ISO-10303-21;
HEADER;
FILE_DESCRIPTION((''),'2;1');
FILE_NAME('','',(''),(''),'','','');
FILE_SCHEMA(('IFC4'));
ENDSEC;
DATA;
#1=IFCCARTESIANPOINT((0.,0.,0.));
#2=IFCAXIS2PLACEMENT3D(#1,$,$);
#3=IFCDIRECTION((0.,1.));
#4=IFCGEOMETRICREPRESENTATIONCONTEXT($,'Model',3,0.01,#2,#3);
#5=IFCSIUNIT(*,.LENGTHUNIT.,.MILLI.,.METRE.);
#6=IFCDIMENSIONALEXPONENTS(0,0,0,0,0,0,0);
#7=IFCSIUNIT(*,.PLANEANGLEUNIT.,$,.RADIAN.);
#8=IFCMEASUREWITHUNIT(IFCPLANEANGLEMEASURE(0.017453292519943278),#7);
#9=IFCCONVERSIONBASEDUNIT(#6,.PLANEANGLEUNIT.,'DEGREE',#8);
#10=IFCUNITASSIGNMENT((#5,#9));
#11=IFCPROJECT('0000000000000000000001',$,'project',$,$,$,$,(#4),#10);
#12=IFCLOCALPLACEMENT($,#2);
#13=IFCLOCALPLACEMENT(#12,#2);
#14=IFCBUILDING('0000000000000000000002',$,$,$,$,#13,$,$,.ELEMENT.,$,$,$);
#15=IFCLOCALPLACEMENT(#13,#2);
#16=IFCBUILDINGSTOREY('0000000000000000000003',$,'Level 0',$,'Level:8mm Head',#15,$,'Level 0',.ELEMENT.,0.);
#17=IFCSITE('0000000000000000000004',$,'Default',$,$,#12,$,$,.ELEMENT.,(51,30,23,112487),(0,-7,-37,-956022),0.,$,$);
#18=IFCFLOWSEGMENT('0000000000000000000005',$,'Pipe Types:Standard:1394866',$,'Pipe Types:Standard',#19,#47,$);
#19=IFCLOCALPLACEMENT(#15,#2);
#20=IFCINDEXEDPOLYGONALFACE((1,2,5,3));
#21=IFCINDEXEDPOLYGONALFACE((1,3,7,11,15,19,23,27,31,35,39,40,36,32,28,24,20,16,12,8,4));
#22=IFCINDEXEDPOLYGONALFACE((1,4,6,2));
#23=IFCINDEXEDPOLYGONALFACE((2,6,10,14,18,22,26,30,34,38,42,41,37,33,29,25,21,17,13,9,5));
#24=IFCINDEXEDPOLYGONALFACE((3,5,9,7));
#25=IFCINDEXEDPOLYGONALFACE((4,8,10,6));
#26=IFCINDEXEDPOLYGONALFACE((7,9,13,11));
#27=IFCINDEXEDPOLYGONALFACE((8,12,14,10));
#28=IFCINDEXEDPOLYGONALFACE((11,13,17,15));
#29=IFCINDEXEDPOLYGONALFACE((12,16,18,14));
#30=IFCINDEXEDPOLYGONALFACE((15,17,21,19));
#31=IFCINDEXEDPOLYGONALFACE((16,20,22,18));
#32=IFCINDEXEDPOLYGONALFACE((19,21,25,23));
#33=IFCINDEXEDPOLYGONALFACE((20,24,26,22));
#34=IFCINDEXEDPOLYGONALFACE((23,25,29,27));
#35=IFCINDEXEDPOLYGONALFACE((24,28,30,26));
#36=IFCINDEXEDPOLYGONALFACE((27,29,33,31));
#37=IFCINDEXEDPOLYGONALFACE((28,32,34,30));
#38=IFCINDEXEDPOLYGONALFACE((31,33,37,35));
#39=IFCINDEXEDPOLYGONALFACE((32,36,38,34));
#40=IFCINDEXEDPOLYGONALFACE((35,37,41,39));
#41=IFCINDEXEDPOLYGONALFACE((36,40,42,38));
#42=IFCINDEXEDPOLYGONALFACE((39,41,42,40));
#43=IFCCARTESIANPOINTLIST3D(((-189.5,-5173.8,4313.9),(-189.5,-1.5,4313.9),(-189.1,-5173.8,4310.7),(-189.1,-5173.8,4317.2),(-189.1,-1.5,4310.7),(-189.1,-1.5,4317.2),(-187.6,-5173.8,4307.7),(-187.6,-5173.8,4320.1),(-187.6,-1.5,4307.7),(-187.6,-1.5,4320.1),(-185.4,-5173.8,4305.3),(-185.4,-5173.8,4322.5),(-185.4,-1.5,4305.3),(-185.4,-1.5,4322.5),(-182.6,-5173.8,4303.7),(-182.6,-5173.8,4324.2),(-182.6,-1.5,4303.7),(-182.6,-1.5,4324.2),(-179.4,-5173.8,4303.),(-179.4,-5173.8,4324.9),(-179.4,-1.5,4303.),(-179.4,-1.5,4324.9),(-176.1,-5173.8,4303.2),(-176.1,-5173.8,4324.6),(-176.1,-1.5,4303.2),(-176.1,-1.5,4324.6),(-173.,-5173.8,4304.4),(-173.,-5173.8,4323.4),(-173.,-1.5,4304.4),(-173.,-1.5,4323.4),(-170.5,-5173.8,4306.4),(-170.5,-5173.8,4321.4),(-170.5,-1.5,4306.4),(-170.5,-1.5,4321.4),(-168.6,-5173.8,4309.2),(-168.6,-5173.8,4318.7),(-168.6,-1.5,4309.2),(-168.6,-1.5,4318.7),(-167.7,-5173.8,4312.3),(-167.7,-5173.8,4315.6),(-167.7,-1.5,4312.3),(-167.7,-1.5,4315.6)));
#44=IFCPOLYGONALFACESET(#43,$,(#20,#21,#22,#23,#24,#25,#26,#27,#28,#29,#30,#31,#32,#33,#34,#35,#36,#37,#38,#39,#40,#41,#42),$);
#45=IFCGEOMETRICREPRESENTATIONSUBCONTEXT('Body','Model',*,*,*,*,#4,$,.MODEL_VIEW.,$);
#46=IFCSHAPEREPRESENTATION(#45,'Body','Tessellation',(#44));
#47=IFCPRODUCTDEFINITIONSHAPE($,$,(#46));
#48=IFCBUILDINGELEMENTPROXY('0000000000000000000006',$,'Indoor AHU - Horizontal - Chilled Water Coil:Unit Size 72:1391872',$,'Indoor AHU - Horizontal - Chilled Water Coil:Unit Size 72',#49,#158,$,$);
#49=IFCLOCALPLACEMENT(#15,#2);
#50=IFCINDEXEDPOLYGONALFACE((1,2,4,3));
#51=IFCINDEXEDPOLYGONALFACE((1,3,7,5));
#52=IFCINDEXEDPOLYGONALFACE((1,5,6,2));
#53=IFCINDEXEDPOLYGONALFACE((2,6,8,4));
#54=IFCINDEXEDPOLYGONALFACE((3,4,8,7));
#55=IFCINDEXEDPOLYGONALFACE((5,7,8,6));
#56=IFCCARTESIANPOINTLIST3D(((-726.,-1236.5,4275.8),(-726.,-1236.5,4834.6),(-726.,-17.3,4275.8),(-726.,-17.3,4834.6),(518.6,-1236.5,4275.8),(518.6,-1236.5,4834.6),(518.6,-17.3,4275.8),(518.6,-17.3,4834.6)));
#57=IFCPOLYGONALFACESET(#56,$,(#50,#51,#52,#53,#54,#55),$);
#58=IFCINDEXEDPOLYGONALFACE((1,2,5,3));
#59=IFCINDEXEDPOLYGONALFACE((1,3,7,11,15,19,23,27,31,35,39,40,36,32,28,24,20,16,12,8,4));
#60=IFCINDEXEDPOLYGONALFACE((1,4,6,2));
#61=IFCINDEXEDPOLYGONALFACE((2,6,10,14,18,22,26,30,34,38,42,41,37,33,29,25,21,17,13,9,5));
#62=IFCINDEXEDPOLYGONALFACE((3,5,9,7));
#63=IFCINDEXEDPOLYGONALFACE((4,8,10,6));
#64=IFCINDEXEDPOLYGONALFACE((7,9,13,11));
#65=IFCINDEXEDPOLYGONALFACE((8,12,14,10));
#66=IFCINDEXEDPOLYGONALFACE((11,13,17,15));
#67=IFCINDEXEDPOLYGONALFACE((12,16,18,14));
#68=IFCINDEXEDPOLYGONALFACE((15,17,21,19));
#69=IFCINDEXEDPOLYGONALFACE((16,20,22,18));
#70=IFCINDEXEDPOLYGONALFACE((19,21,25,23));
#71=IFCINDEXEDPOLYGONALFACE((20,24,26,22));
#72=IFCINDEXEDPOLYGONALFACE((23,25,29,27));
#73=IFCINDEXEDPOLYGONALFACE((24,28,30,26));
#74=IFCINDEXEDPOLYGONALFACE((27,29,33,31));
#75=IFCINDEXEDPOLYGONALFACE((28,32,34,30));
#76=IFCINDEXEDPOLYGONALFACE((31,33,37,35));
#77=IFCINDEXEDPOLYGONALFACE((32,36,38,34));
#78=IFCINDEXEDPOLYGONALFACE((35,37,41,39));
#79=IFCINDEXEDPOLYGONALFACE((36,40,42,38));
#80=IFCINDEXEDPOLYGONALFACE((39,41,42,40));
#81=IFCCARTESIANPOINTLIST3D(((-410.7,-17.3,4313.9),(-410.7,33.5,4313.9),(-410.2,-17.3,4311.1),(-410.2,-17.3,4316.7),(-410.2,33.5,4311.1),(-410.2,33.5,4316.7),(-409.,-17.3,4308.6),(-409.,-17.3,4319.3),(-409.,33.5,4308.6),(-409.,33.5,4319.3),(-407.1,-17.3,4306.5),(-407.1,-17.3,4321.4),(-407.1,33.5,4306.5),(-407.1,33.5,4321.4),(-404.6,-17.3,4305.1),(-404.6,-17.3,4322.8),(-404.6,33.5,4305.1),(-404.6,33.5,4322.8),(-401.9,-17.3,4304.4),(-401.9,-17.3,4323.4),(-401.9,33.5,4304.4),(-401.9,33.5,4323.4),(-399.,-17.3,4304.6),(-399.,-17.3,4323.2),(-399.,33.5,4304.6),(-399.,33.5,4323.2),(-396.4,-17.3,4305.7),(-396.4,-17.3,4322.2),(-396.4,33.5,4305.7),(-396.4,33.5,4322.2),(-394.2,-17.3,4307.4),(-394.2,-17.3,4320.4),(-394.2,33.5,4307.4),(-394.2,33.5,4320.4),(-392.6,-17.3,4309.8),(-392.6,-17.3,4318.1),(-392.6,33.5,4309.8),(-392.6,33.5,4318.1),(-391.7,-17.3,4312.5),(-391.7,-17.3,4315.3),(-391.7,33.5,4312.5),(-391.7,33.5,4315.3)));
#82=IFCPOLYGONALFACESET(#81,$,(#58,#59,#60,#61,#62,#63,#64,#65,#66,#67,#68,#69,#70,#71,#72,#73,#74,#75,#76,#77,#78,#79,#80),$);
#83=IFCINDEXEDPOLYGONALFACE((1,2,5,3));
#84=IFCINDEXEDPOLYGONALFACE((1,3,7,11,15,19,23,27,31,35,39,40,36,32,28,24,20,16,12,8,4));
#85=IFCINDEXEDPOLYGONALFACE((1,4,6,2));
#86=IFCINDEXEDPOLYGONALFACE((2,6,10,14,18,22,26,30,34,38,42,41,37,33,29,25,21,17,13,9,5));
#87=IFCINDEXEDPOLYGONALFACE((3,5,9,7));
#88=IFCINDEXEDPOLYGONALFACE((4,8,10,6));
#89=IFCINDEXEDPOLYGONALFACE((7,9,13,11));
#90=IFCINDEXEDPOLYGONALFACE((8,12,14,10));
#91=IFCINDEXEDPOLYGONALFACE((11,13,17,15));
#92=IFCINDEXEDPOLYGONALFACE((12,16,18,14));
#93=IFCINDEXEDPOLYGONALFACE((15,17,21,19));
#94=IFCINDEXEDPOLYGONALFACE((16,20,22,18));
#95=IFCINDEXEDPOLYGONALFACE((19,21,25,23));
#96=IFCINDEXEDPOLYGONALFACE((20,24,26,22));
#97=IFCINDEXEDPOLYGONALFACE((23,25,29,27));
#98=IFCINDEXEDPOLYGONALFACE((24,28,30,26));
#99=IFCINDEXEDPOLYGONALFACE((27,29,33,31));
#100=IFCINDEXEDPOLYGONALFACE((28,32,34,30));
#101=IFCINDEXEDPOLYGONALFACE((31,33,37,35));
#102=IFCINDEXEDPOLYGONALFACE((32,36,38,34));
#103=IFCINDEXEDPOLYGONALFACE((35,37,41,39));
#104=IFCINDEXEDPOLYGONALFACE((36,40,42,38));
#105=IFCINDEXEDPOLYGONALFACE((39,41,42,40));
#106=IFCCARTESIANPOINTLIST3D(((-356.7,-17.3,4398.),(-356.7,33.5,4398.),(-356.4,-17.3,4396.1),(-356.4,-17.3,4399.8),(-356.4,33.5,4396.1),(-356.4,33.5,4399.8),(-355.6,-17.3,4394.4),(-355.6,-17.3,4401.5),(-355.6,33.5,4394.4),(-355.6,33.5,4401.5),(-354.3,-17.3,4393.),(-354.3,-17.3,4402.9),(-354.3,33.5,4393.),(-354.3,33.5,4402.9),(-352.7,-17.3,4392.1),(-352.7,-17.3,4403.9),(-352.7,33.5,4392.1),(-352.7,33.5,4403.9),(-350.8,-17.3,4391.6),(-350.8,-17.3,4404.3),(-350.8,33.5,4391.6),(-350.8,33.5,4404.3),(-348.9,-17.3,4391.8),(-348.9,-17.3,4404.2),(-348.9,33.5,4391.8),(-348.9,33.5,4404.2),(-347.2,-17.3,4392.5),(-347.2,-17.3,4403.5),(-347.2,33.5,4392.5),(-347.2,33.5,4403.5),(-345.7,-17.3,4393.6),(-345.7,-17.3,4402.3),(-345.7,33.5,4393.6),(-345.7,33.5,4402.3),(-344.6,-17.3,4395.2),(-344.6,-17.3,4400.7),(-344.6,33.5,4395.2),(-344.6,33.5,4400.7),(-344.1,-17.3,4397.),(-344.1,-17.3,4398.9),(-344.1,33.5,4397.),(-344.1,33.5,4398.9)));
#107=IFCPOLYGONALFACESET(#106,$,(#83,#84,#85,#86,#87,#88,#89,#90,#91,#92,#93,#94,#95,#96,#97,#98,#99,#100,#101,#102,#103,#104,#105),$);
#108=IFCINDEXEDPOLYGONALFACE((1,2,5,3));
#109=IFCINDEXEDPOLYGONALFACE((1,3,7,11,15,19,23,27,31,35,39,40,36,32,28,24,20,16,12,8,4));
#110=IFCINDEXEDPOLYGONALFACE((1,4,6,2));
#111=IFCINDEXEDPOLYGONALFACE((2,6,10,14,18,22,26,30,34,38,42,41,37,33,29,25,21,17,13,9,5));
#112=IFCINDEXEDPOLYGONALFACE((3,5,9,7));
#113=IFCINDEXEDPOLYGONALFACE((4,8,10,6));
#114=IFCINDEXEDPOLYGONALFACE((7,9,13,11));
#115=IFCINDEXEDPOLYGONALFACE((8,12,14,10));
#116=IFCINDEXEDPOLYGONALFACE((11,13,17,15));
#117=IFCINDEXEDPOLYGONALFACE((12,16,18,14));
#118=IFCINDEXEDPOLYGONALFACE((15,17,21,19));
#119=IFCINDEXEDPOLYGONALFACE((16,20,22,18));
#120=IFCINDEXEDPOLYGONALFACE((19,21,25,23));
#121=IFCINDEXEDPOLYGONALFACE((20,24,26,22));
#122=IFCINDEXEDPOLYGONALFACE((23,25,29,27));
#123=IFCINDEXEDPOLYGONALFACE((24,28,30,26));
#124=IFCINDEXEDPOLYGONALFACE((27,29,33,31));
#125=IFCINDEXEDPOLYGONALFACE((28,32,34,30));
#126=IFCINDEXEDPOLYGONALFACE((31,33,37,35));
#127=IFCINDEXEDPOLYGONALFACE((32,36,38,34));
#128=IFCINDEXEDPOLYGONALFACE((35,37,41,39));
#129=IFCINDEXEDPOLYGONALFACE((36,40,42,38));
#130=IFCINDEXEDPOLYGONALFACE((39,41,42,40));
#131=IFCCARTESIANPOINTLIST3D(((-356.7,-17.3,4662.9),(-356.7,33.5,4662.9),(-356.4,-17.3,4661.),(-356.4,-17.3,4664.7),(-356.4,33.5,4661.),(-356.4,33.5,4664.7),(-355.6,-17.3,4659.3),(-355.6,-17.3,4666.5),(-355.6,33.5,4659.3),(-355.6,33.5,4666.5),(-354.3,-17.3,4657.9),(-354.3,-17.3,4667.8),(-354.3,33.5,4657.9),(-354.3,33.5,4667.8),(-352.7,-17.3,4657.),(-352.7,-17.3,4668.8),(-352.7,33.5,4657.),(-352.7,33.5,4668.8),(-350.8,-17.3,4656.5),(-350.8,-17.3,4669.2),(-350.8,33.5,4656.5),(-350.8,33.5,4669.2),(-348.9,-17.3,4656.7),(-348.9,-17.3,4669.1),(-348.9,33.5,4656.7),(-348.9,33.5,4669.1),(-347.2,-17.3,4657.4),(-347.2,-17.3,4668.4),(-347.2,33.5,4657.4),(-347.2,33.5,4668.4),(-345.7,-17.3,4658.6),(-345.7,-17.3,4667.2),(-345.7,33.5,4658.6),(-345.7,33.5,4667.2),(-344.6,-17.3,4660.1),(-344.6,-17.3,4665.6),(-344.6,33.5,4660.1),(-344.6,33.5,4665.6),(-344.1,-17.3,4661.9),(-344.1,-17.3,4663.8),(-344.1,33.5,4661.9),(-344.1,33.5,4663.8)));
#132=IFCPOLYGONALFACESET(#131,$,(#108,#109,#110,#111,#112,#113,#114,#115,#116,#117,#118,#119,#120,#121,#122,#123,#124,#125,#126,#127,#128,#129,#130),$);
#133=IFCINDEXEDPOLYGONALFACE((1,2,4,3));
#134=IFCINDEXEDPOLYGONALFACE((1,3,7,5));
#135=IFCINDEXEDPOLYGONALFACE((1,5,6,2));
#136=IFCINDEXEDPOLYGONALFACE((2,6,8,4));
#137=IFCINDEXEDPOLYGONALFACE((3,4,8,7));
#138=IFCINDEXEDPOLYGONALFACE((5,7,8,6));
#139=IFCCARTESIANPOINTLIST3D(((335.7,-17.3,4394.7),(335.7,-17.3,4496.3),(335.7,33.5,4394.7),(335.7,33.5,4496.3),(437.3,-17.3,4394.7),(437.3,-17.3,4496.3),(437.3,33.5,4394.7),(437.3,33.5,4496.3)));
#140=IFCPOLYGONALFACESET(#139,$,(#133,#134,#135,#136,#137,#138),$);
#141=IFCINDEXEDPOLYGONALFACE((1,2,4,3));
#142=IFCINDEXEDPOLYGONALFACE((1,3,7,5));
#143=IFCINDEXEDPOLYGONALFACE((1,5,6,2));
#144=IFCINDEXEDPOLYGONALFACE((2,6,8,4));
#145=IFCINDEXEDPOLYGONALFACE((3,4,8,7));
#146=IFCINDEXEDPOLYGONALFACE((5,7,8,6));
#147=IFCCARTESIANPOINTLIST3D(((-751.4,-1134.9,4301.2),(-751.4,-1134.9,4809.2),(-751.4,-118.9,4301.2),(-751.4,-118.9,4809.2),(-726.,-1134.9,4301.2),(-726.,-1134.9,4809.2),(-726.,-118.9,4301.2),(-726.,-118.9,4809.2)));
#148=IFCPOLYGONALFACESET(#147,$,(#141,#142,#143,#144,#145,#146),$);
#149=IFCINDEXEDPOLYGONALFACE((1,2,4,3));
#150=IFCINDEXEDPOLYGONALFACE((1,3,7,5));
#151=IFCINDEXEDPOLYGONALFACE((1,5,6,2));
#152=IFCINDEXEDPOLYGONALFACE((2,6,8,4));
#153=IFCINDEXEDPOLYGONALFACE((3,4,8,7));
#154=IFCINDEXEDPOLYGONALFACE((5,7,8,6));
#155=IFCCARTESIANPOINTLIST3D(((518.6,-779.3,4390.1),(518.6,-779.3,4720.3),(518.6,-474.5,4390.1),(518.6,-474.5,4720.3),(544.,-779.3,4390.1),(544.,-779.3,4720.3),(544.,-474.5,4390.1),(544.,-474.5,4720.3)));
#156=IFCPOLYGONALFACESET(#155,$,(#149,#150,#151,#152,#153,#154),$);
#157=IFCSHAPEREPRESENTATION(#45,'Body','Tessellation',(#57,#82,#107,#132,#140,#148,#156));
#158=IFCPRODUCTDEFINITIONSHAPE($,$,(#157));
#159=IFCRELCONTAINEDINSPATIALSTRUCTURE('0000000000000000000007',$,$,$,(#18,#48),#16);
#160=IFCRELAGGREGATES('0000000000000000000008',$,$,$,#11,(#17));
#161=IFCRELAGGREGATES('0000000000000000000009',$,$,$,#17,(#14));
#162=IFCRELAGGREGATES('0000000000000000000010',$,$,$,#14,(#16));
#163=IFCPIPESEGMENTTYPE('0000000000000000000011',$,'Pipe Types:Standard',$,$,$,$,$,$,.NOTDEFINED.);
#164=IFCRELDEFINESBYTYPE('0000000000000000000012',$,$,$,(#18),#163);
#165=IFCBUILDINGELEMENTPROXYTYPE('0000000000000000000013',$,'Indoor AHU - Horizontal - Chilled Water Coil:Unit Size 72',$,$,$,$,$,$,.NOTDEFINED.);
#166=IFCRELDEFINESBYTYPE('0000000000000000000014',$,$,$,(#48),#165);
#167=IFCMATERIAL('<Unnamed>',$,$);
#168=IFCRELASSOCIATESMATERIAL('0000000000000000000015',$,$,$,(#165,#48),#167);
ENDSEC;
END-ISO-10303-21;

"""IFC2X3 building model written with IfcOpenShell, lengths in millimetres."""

from ifc_helpers import new_model, entity, si_unit, converted_unit, direction, frame, frame_2d, origin, origin_2d_with_axis, place, context, subcontext, project, spatial, rectangle, circle, extrude, source, transform, mapped, material, type_object, type_shapes, element, save


model = new_model("IFC2X3")

# Units and contexts
model_context = context("Model", 3, precision=0.01, world=origin(), true_north=direction((0.0, 1.0)))
body_context = subcontext(model_context, "Body", "Model", "MODEL_VIEW")
ifc_project = project(units=[si_unit("LENGTHUNIT", "METRE", prefix="MILLI"), converted_unit("PLANEANGLEUNIT", "DEGREE", entity("IfcPlaneAngleMeasure", 0.017453292519943278), si_unit("PLANEANGLEUNIT", "RADIAN"), dimensions=[0, 0, 0, 0, 0, 0, 0])], contexts=[model_context])

# Site, building, storey
site_placement = place(None, origin())
site = spatial("IfcSite", under=ifc_project, at=site_placement, Name="Default", CompositionType="ELEMENT", RefLatitude=(51, 30, 23, 112487), RefLongitude=(0, -7, -37, -956022), RefElevation=0.0)
building_placement = place(site_placement, origin())
building = spatial("IfcBuilding", under=site, at=building_placement, CompositionType="ELEMENT")
storey_placement = place(building_placement, origin())
storey = spatial("IfcBuildingStorey", under=building, at=storey_placement, Name="Level 0", ObjectType="Level:8mm Head", LongName="Level 0", CompositionType="ELEMENT", Elevation=0.0)

# Shared definitions
ifc_material = material(Name="<Unnamed>")

# Flow segment
pipe_segment_type = type_object("IfcPipeSegmentType", Name="Pipe Types:Standard", PredefinedType="NOTDEFINED")
flow_segment_1_placement = place(storey_placement, origin())
element("IfcFlowSegment", 1, at=flow_segment_1_placement, inside=storey, type_object=pipe_segment_type, Name="Pipe Types:Standard:1394866", ObjectType="Pipe Types:Standard", context=body_context, shape_type="SweptSolid", body=[
    extrude(circle(Radius=11.0, at=frame_2d((0.0, 0.0), x_axis=(1.0, 0.0))), frame((-178.5, -5173.8, 4313.9), z_axis=(0.0, 1.0, 0.0), x_axis=(-1.0, 0.0, 0.0)), (0.0, 0.0, 1.0), 5172.3),
])

# Building element proxy
building_element_proxy_type = type_object("IfcBuildingElementProxyType", Name="Indoor AHU - Horizontal - Chilled Water Coil:Unit Size 72", PredefinedType="NOTDEFINED", material=ifc_material)
shared_shape_1 = source(origin(), body_context, "Body", "SweptSolid", [
    extrude(rectangle(XDim=1244.6, YDim=1219.2, at=origin_2d_with_axis()), frame((622.3, 609.6, 0.0), z_axis=(0.0, 0.0, 1.0), x_axis=(-1.0, 0.0, 0.0)), (0.0, 0.0, 1.0), 558.8),
    extrude(circle(Radius=9.5, at=frame_2d((0.0, 0.0), x_axis=(1.0, 0.0))), frame((919.7, -50.8, 38.1), z_axis=(0.0, 1.0, 0.0), x_axis=(1.0, 0.0, 0.0)), (0.0, 0.0, 1.0), 50.8),
    extrude(circle(Radius=6.4, at=frame_2d((0.0, 0.0), x_axis=(1.0, 0.0))), frame((868.9, -50.8, 122.1), z_axis=(0.0, 1.0, 0.0), x_axis=(1.0, 0.0, 0.0)), (0.0, 0.0, 1.0), 50.8),
    extrude(circle(Radius=6.4, at=frame_2d((0.0, 0.0), x_axis=(1.0, 0.0))), frame((868.9, -50.8, 387.1), z_axis=(0.0, 1.0, 0.0), x_axis=(1.0, 0.0, 0.0)), (0.0, 0.0, 1.0), 50.8),
    extrude(rectangle(XDim=50.8, YDim=101.6, at=frame_2d((0.0, 0.0), x_axis=(1.0, 0.0))), frame((132.1, -25.4, 118.9), z_axis=(0.0, 0.0, 1.0), x_axis=(0.0, 1.0, 0.0)), (0.0, 0.0, 1.0), 101.6),
    extrude(rectangle(XDim=25.4, YDim=1016.0, at=origin_2d_with_axis()), frame((1257.3, 609.6, 25.4), z_axis=(0.0, 0.0, 1.0), x_axis=(-1.0, 0.0, 0.0)), (0.0, 0.0, 1.0), 508.0),
    extrude(rectangle(XDim=25.4, YDim=304.8, at=frame_2d((0.0, 0.0), x_axis=(1.0, 0.0))), frame((-12.7, 609.6, 114.3), z_axis=(0.0, 0.0, 1.0), x_axis=(-1.0, 0.0, 0.0)), (0.0, 0.0, 1.0), 330.2),
])
type_shapes(building_element_proxy_type, [shared_shape_1])
proxy_placement = place(storey_placement, frame((518.6, -17.3, 4275.8), z_axis=(0.0, 0.0, 1.0), x_axis=(-1.0, 0.0, 0.0)))
element("IfcBuildingElementProxy", 2, at=proxy_placement, inside=storey, type_object=building_element_proxy_type, material=ifc_material, Name="Indoor AHU - Horizontal - Chilled Water Coil:Unit Size 72:1391872", ObjectType="Indoor AHU - Horizontal - Chilled Water Coil:Unit Size 72", context=body_context, shape_type="MappedRepresentation", body=[
    mapped(shared_shape_1, transform((0.0, 0.0, 0.0), scale=1.0)),
])

save(model, "model.ifc")
